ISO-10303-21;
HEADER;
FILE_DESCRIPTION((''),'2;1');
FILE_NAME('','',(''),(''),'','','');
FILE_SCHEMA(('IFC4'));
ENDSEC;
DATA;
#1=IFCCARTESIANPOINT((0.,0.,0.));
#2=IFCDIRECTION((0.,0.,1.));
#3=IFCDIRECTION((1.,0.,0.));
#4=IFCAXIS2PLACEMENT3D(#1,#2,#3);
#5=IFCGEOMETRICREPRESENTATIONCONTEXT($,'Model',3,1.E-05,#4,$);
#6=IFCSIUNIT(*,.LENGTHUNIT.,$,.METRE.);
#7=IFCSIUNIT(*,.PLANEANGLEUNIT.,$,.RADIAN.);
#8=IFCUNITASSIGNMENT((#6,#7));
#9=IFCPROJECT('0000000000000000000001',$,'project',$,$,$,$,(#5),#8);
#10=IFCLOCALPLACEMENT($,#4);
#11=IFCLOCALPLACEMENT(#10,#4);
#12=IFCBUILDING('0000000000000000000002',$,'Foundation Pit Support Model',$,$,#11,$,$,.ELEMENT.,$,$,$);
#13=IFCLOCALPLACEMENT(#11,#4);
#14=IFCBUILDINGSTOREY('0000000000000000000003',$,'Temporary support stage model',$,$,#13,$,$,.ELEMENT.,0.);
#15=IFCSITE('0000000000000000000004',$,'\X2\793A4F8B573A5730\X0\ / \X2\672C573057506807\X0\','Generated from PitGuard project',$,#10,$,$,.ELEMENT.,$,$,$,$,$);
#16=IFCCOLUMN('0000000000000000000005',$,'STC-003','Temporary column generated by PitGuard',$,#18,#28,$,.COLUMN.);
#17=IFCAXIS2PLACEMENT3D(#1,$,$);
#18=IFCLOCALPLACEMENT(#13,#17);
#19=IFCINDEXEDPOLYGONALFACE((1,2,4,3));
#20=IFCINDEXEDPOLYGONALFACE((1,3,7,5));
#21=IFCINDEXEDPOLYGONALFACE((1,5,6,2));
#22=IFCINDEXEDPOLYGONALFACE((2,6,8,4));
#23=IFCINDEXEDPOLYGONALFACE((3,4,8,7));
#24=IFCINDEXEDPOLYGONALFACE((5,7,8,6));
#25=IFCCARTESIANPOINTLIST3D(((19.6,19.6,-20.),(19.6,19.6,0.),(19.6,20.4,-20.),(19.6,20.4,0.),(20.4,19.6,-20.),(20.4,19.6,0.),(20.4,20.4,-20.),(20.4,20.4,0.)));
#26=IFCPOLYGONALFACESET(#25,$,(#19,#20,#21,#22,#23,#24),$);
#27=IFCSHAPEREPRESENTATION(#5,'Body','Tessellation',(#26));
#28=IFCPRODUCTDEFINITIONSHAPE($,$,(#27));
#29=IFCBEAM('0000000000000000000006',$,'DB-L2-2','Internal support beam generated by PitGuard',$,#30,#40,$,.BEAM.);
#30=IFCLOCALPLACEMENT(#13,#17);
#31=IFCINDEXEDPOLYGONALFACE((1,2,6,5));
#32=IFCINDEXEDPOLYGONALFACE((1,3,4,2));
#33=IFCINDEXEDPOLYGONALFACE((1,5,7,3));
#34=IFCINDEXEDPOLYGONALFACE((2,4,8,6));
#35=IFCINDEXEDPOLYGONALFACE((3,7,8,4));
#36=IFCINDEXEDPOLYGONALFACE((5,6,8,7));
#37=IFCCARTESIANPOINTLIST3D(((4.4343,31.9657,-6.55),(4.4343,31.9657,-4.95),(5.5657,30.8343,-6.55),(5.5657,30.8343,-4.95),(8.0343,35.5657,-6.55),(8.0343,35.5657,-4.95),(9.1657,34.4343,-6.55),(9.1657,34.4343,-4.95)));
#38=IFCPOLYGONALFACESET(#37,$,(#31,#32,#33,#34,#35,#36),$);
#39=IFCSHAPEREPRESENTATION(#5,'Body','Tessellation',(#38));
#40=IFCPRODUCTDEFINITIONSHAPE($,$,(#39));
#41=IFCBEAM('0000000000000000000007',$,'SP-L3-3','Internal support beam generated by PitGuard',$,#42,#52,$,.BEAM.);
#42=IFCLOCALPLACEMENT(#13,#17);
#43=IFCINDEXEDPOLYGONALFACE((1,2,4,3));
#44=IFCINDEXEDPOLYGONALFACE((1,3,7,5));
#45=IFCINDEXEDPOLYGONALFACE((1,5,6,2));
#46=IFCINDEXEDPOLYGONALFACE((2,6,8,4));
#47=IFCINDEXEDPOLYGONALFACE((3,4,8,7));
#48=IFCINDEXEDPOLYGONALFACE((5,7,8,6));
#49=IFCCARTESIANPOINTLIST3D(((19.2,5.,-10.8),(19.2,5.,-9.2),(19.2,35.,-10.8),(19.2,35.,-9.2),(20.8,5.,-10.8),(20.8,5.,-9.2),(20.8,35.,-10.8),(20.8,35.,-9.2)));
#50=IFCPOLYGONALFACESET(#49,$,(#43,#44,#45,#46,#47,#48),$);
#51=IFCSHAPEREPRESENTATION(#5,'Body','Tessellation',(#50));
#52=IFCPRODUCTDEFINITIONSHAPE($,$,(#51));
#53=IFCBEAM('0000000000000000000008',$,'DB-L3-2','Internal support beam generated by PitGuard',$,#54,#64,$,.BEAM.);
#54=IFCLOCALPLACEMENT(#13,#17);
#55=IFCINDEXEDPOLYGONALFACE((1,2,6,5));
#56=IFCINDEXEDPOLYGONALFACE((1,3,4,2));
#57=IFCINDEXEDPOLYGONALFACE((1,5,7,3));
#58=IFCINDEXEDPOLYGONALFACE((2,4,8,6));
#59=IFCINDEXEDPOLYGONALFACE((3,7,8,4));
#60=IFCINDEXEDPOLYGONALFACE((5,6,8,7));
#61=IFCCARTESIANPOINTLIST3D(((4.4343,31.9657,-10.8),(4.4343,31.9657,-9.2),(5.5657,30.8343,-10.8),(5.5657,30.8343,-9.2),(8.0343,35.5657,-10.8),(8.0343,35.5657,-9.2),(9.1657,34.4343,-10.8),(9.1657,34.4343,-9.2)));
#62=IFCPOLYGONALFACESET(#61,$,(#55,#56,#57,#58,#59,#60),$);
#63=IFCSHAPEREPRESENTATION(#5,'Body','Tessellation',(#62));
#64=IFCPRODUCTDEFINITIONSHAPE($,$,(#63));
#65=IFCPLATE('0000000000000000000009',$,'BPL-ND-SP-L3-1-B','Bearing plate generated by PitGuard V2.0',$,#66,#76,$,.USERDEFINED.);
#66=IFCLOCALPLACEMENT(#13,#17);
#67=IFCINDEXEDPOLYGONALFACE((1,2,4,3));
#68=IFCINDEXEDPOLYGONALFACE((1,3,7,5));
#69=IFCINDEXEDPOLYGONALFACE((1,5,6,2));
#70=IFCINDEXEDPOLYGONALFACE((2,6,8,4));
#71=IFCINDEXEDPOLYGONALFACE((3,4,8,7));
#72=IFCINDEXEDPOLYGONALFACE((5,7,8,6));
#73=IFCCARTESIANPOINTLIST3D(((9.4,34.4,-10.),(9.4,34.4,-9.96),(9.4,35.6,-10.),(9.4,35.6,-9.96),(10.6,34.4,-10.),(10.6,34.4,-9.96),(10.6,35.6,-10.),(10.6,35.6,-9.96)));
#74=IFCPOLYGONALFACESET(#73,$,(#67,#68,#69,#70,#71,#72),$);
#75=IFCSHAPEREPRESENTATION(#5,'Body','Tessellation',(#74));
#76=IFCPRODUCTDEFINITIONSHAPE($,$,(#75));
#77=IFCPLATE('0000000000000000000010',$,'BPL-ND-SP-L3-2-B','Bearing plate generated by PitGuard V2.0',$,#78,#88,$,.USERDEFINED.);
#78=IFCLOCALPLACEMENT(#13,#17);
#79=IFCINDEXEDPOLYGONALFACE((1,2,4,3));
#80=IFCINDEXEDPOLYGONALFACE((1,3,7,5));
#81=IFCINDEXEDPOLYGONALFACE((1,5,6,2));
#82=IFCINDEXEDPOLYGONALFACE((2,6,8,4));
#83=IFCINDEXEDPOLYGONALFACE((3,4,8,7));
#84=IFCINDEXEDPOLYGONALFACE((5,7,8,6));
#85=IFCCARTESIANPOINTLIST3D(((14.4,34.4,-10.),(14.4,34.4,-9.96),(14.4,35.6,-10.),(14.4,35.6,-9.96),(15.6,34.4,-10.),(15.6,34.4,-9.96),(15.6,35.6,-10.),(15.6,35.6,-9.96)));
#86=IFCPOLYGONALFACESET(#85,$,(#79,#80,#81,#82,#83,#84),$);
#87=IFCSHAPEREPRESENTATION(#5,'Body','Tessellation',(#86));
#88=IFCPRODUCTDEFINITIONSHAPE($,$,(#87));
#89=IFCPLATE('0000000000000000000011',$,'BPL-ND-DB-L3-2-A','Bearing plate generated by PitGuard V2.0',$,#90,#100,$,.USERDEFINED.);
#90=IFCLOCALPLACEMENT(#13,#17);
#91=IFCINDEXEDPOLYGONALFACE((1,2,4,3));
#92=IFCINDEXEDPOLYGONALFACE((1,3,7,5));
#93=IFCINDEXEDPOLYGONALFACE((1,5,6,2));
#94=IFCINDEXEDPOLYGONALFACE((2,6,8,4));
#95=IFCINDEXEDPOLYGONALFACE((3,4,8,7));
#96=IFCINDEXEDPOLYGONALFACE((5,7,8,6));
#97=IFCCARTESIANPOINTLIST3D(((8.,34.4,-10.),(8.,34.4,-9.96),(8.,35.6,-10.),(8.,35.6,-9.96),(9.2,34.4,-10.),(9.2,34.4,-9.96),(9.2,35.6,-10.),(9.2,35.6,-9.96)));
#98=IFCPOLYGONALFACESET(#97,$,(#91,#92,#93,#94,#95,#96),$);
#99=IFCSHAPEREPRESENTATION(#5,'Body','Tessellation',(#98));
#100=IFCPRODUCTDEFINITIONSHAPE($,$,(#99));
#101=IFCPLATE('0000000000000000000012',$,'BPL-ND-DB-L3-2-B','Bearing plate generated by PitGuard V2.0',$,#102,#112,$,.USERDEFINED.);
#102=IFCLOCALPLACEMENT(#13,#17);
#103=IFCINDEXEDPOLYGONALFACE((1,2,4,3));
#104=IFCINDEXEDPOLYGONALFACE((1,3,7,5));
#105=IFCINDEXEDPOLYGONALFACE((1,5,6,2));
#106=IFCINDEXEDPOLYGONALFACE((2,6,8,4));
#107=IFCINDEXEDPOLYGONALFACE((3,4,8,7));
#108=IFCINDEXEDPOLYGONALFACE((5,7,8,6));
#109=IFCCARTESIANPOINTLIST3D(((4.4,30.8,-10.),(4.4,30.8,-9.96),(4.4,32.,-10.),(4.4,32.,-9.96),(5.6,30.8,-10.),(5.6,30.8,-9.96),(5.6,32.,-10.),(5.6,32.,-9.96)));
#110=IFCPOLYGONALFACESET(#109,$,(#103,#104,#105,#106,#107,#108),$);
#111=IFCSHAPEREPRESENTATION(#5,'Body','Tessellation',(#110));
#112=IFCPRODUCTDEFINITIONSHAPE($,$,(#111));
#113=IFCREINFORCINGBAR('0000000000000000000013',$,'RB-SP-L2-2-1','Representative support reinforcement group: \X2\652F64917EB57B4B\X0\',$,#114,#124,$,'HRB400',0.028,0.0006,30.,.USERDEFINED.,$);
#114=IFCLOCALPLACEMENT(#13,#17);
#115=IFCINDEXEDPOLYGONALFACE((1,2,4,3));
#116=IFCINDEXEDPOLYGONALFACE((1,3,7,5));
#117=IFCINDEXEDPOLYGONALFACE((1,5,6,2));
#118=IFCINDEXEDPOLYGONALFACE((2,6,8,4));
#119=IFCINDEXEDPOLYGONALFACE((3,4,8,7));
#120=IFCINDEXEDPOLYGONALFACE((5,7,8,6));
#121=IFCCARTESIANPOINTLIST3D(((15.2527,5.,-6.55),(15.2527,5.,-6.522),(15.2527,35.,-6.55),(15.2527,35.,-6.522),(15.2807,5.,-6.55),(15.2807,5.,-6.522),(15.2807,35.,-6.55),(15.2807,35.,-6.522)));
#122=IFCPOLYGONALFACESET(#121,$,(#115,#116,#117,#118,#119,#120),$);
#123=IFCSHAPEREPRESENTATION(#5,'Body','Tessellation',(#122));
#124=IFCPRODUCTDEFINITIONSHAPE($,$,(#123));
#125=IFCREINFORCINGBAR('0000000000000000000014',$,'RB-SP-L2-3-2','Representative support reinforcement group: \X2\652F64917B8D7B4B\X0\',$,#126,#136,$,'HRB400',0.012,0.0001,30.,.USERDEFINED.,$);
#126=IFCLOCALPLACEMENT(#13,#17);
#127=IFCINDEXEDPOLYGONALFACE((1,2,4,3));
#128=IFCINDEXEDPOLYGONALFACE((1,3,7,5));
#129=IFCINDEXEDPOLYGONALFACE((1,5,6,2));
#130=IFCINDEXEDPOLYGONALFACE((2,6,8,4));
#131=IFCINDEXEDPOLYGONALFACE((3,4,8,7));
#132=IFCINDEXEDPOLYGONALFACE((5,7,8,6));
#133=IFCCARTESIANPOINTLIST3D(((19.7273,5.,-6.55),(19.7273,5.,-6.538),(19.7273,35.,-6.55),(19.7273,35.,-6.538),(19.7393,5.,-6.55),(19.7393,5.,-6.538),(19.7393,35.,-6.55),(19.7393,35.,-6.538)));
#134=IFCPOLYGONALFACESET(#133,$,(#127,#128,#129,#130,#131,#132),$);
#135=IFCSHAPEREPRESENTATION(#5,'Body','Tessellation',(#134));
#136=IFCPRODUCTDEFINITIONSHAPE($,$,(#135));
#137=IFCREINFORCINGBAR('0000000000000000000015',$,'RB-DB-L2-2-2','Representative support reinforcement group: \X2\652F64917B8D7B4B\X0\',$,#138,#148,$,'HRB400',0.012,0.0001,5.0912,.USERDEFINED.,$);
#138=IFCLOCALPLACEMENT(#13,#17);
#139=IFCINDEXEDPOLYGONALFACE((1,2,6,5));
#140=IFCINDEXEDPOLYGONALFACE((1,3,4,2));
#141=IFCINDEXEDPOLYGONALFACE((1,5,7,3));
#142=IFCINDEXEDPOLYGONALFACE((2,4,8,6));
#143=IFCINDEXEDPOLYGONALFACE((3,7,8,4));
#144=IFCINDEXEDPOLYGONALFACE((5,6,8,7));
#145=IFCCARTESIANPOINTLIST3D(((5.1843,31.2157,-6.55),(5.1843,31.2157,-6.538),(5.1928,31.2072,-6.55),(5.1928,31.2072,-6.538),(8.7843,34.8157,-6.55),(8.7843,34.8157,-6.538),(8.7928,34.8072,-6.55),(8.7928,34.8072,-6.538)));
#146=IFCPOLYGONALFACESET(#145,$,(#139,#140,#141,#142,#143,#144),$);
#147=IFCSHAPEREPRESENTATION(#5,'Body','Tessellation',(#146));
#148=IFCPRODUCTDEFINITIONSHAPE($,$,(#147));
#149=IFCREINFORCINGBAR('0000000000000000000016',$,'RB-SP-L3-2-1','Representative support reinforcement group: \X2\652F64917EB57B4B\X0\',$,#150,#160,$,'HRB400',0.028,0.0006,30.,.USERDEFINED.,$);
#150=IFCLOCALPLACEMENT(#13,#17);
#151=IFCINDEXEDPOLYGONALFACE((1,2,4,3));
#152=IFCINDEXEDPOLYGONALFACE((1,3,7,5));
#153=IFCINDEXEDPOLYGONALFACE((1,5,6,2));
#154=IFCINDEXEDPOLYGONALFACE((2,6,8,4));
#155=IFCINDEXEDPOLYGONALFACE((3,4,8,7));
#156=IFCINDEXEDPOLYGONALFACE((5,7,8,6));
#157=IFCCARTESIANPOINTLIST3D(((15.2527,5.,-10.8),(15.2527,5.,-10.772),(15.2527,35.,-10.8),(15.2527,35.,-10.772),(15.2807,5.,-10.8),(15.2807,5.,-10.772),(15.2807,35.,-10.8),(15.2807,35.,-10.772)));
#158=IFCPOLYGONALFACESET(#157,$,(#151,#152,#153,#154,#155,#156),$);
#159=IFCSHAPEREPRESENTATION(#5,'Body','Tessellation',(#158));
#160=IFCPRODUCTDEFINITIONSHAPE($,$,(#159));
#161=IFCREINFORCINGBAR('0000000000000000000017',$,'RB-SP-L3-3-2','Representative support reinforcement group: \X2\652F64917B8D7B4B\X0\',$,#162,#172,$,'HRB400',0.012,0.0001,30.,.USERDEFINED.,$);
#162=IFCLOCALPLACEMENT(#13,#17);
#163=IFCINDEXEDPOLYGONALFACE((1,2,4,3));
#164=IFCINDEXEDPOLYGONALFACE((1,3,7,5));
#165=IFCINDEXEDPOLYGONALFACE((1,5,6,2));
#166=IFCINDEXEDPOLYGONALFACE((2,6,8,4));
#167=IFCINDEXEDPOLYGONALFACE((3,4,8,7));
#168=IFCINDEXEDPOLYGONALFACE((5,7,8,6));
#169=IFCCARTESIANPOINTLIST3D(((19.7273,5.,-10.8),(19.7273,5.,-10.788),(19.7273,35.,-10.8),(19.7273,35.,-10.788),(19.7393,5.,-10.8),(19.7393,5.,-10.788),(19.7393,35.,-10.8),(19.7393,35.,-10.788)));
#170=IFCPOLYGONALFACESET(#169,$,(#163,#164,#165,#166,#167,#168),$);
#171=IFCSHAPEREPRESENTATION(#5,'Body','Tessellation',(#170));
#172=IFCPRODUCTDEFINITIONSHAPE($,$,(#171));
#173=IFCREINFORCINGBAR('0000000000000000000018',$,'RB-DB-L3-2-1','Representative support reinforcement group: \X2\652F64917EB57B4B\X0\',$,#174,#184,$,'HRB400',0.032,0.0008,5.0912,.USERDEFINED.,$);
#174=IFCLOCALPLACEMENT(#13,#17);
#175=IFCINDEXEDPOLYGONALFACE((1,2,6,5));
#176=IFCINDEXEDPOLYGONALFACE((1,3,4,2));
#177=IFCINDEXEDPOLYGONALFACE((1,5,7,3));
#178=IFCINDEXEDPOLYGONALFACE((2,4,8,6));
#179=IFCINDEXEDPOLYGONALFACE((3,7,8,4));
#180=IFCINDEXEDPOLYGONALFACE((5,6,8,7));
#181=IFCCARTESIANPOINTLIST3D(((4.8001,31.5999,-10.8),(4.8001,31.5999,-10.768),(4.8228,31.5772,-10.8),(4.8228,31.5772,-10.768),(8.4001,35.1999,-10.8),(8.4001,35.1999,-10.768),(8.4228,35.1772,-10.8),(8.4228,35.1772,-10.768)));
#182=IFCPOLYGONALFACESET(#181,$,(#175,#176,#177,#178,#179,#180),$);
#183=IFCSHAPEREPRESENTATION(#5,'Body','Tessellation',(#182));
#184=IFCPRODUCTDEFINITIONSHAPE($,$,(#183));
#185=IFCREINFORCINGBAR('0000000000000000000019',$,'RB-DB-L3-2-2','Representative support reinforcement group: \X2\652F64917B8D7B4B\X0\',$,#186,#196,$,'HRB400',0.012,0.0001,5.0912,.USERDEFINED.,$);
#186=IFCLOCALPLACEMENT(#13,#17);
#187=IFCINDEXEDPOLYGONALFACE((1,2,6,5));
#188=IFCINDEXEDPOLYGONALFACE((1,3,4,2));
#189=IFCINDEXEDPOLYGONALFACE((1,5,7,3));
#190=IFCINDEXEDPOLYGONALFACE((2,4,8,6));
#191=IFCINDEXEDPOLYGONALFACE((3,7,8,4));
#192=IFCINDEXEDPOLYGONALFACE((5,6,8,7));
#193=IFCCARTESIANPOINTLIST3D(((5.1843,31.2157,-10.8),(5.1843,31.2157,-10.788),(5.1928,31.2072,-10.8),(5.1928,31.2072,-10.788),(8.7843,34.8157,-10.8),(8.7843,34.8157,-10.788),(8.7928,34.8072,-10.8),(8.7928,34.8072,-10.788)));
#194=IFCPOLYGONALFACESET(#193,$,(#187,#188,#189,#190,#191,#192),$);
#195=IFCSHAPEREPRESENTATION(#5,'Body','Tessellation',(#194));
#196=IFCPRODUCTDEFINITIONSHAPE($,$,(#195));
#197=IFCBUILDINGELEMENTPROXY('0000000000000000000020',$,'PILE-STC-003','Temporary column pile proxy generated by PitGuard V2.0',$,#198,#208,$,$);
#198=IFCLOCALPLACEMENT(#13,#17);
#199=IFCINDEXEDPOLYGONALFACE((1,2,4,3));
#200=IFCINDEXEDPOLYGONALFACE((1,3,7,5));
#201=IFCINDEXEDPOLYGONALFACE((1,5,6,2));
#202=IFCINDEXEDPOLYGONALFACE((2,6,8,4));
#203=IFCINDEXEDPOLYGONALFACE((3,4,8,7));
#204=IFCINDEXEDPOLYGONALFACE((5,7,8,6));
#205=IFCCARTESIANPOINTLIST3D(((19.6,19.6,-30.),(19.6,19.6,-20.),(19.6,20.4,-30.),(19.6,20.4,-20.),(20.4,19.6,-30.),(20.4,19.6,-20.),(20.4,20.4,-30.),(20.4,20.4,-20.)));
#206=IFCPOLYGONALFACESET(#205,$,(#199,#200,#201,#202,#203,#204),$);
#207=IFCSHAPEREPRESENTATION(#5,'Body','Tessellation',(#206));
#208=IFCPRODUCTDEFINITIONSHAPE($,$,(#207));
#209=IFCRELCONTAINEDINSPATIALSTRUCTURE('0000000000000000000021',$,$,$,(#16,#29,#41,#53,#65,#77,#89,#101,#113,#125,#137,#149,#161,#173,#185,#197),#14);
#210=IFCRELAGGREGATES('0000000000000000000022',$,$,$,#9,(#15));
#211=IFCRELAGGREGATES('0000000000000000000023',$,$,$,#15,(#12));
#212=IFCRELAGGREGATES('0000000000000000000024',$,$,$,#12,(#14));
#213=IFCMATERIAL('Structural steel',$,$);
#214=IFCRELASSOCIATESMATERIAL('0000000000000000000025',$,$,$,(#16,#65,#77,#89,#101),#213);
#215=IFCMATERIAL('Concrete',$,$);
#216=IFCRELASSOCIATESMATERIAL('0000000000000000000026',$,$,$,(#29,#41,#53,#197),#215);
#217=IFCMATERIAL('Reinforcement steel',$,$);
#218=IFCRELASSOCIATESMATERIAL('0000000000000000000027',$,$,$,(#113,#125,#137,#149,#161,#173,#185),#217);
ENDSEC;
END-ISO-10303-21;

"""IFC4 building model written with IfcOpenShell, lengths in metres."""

from ifc_helpers import new_model, si_unit, frame, origin_with_axes, origin_2d, place, context, project, spatial, rectangle, extrude, material, element, save


model = new_model("IFC4")

# Units and contexts
model_context = context("Model", 3, precision=1e-05, world=origin_with_axes())
ifc_project = project(units=[si_unit("LENGTHUNIT", "METRE"), si_unit("PLANEANGLEUNIT", "RADIAN")], contexts=[model_context])

# Site, building, storey
site_placement = place(None, origin_with_axes())
site = spatial("IfcSite", under=ifc_project, at=site_placement, Name="示例场地 / 本地坐标", Description="Generated from PitGuard project", CompositionType="ELEMENT")
building_placement = place(site_placement, origin_with_axes())
building = spatial("IfcBuilding", under=site, at=building_placement, Name="Foundation Pit Support Model", CompositionType="ELEMENT")
storey_placement = place(building_placement, origin_with_axes())
storey = spatial("IfcBuildingStorey", under=building, at=storey_placement, Name="Temporary support stage model", CompositionType="ELEMENT", Elevation=0.0)

# Column
ifc_material_1 = material(Name="Structural steel")
column_placement = place(storey_placement, frame((20.0, 20.0, -20.0), z_axis=(0.0, 0.0, 1.0), x_axis=(1.0, 0.0, 0.0)))
element("IfcColumn", 1, at=column_placement, inside=storey, material=ifc_material_1, Name="STC-003", Description="Temporary column generated by PitGuard", PredefinedType="COLUMN", context=model_context, shape_type="SweptSolid", body=[
    extrude(rectangle(XDim=0.8, YDim=0.8, at=origin_2d()), origin_with_axes(), (0.0, 0.0, 1.0), 20.0),
])

# Beams
ifc_material_2 = material(Name="Concrete")
beam_1_placement = place(storey_placement, frame((6.8, 33.2, -6.55), z_axis=(0.0, 0.0, 1.0), x_axis=(-0.707107, -0.707107, 0.0)))
element("IfcBeam", 2, at=beam_1_placement, inside=storey, material=ifc_material_2, Name="DB-L2-2", Description="Internal support beam generated by PitGuard", PredefinedType="BEAM", context=model_context, shape_type="SweptSolid", body=[
    extrude(rectangle(XDim=5.0912, YDim=1.6, at=origin_2d()), origin_with_axes(), (0.0, 0.0, 1.0), 1.6),
])
beam_2_placement = place(storey_placement, frame((20.0, 20.0, -10.8), z_axis=(0.0, 0.0, 1.0), x_axis=(0.0, 1.0, 0.0)))
element("IfcBeam", 3, at=beam_2_placement, inside=storey, material=ifc_material_2, Name="SP-L3-3", Description="Internal support beam generated by PitGuard", PredefinedType="BEAM", context=model_context, shape_type="SweptSolid", body=[
    extrude(rectangle(XDim=30.0, YDim=1.6, at=origin_2d()), origin_with_axes(), (0.0, 0.0, 1.0), 1.6),
])
beam_3_placement = place(storey_placement, frame((6.8, 33.2, -10.8), z_axis=(0.0, 0.0, 1.0), x_axis=(-0.707107, -0.707107, 0.0)))
element("IfcBeam", 4, at=beam_3_placement, inside=storey, material=ifc_material_2, Name="DB-L3-2", Description="Internal support beam generated by PitGuard", PredefinedType="BEAM", context=model_context, shape_type="SweptSolid", body=[
    extrude(rectangle(XDim=5.0912, YDim=1.6, at=origin_2d()), origin_with_axes(), (0.0, 0.0, 1.0), 1.6),
])

# Plates
for number, where, z_axis, x_axis, name in (
    (5, (10.0, 35.0, -10.0), (0.0, 0.0, 1.0), (1.0, 0.0, 0.0), "BPL-ND-SP-L3-1-B"),
    (6, (15.0, 35.0, -10.0), (0.0, 0.0, 1.0), (1.0, 0.0, 0.0), "BPL-ND-SP-L3-2-B"),
    (7, (8.6, 35.0, -10.0), (0.0, 0.0, 1.0), (1.0, 0.0, 0.0), "BPL-ND-DB-L3-2-A"),
    (8, (5.0, 31.4, -10.0), (0.0, 0.0, 1.0), (1.0, 0.0, 0.0), "BPL-ND-DB-L3-2-B"),
):
    element("IfcPlate", number, at=place(storey_placement, frame(where, z_axis=z_axis, x_axis=x_axis)), inside=storey, material=ifc_material_1, Name=name, Description="Bearing plate generated by PitGuard V2.0", PredefinedType="USERDEFINED", context=model_context, shape_type="SweptSolid", body=[
        extrude(rectangle(XDim=1.2, YDim=1.2, at=origin_2d()), origin_with_axes(), (0.0, 0.0, 1.0), 0.04),
    ])

# Reinforcing bars
ifc_material_3 = material(Name="Reinforcement steel")
reinforcing_bar_1_placement = place(storey_placement, frame((15.2667, 20.0, -6.55), z_axis=(0.0, 0.0, 1.0), x_axis=(0.0, 1.0, 0.0)))
element("IfcReinforcingBar", 9, at=reinforcing_bar_1_placement, inside=storey, material=ifc_material_3, Name="RB-SP-L2-2-1", Description="Representative support reinforcement group: 支撑纵筋", SteelGrade="HRB400", BarLength=30.0, CrossSectionArea=0.0006, NominalDiameter=0.028, PredefinedType="USERDEFINED", context=model_context, shape_type="SweptSolid", body=[
    extrude(rectangle(XDim=30.0, YDim=0.028, at=origin_2d()), origin_with_axes(), (0.0, 0.0, 1.0), 0.028),
])
reinforcing_bar_2_placement = place(storey_placement, frame((19.7333, 20.0, -6.55), z_axis=(0.0, 0.0, 1.0), x_axis=(0.0, 1.0, 0.0)))
element("IfcReinforcingBar", 10, at=reinforcing_bar_2_placement, inside=storey, material=ifc_material_3, Name="RB-SP-L2-3-2", Description="Representative support reinforcement group: 支撑箍筋", SteelGrade="HRB400", BarLength=30.0, CrossSectionArea=0.0001, NominalDiameter=0.012, PredefinedType="USERDEFINED", context=model_context, shape_type="SweptSolid", body=[
    extrude(rectangle(XDim=30.0, YDim=0.012, at=origin_2d()), origin_with_axes(), (0.0, 0.0, 1.0), 0.012),
])
reinforcing_bar_3_placement = place(storey_placement, frame((6.9886, 33.0114, -6.55), z_axis=(0.0, 0.0, 1.0), x_axis=(-0.707107, -0.707107, 0.0)))
element("IfcReinforcingBar", 11, at=reinforcing_bar_3_placement, inside=storey, material=ifc_material_3, Name="RB-DB-L2-2-2", Description="Representative support reinforcement group: 支撑箍筋", SteelGrade="HRB400", BarLength=5.0912, CrossSectionArea=0.0001, NominalDiameter=0.012, PredefinedType="USERDEFINED", context=model_context, shape_type="SweptSolid", body=[
    extrude(rectangle(XDim=5.0912, YDim=0.012, at=origin_2d()), origin_with_axes(), (0.0, 0.0, 1.0), 0.012),
])
reinforcing_bar_4_placement = place(storey_placement, frame((15.2667, 20.0, -10.8), z_axis=(0.0, 0.0, 1.0), x_axis=(0.0, 1.0, 0.0)))
element("IfcReinforcingBar", 12, at=reinforcing_bar_4_placement, inside=storey, material=ifc_material_3, Name="RB-SP-L3-2-1", Description="Representative support reinforcement group: 支撑纵筋", SteelGrade="HRB400", BarLength=30.0, CrossSectionArea=0.0006, NominalDiameter=0.028, PredefinedType="USERDEFINED", context=model_context, shape_type="SweptSolid", body=[
    extrude(rectangle(XDim=30.0, YDim=0.028, at=origin_2d()), origin_with_axes(), (0.0, 0.0, 1.0), 0.028),
])
reinforcing_bar_5_placement = place(storey_placement, frame((19.7333, 20.0, -10.8), z_axis=(0.0, 0.0, 1.0), x_axis=(0.0, 1.0, 0.0)))
element("IfcReinforcingBar", 13, at=reinforcing_bar_5_placement, inside=storey, material=ifc_material_3, Name="RB-SP-L3-3-2", Description="Representative support reinforcement group: 支撑箍筋", SteelGrade="HRB400", BarLength=30.0, CrossSectionArea=0.0001, NominalDiameter=0.012, PredefinedType="USERDEFINED", context=model_context, shape_type="SweptSolid", body=[
    extrude(rectangle(XDim=30.0, YDim=0.012, at=origin_2d()), origin_with_axes(), (0.0, 0.0, 1.0), 0.012),
])
reinforcing_bar_6_placement = place(storey_placement, frame((6.6114, 33.3886, -10.8), z_axis=(0.0, 0.0, 1.0), x_axis=(-0.707107, -0.707107, 0.0)))
element("IfcReinforcingBar", 14, at=reinforcing_bar_6_placement, inside=storey, material=ifc_material_3, Name="RB-DB-L3-2-1", Description="Representative support reinforcement group: 支撑纵筋", SteelGrade="HRB400", BarLength=5.0912, CrossSectionArea=0.0008, NominalDiameter=0.032, PredefinedType="USERDEFINED", context=model_context, shape_type="SweptSolid", body=[
    extrude(rectangle(XDim=5.0912, YDim=0.032, at=origin_2d()), origin_with_axes(), (0.0, 0.0, 1.0), 0.032),
])
reinforcing_bar_7_placement = place(storey_placement, frame((6.9886, 33.0114, -10.8), z_axis=(0.0, 0.0, 1.0), x_axis=(-0.707107, -0.707107, 0.0)))
element("IfcReinforcingBar", 15, at=reinforcing_bar_7_placement, inside=storey, material=ifc_material_3, Name="RB-DB-L3-2-2", Description="Representative support reinforcement group: 支撑箍筋", SteelGrade="HRB400", BarLength=5.0912, CrossSectionArea=0.0001, NominalDiameter=0.012, PredefinedType="USERDEFINED", context=model_context, shape_type="SweptSolid", body=[
    extrude(rectangle(XDim=5.0912, YDim=0.012, at=origin_2d()), origin_with_axes(), (0.0, 0.0, 1.0), 0.012),
])

# Building element proxy
proxy_1_placement = place(storey_placement, frame((20.0, 20.0, -30.0), z_axis=(0.0, 0.0, 1.0), x_axis=(1.0, 0.0, 0.0)))
element("IfcBuildingElementProxy", 16, at=proxy_1_placement, inside=storey, material=ifc_material_2, Name="PILE-STC-003", Description="Temporary column pile proxy generated by PitGuard V2.0", context=model_context, shape_type="SweptSolid", body=[
    extrude(rectangle(XDim=0.8, YDim=0.8, at=origin_2d()), origin_with_axes(), (0.0, 0.0, 1.0), 10.0),
])

save(model, "model.ifc")
